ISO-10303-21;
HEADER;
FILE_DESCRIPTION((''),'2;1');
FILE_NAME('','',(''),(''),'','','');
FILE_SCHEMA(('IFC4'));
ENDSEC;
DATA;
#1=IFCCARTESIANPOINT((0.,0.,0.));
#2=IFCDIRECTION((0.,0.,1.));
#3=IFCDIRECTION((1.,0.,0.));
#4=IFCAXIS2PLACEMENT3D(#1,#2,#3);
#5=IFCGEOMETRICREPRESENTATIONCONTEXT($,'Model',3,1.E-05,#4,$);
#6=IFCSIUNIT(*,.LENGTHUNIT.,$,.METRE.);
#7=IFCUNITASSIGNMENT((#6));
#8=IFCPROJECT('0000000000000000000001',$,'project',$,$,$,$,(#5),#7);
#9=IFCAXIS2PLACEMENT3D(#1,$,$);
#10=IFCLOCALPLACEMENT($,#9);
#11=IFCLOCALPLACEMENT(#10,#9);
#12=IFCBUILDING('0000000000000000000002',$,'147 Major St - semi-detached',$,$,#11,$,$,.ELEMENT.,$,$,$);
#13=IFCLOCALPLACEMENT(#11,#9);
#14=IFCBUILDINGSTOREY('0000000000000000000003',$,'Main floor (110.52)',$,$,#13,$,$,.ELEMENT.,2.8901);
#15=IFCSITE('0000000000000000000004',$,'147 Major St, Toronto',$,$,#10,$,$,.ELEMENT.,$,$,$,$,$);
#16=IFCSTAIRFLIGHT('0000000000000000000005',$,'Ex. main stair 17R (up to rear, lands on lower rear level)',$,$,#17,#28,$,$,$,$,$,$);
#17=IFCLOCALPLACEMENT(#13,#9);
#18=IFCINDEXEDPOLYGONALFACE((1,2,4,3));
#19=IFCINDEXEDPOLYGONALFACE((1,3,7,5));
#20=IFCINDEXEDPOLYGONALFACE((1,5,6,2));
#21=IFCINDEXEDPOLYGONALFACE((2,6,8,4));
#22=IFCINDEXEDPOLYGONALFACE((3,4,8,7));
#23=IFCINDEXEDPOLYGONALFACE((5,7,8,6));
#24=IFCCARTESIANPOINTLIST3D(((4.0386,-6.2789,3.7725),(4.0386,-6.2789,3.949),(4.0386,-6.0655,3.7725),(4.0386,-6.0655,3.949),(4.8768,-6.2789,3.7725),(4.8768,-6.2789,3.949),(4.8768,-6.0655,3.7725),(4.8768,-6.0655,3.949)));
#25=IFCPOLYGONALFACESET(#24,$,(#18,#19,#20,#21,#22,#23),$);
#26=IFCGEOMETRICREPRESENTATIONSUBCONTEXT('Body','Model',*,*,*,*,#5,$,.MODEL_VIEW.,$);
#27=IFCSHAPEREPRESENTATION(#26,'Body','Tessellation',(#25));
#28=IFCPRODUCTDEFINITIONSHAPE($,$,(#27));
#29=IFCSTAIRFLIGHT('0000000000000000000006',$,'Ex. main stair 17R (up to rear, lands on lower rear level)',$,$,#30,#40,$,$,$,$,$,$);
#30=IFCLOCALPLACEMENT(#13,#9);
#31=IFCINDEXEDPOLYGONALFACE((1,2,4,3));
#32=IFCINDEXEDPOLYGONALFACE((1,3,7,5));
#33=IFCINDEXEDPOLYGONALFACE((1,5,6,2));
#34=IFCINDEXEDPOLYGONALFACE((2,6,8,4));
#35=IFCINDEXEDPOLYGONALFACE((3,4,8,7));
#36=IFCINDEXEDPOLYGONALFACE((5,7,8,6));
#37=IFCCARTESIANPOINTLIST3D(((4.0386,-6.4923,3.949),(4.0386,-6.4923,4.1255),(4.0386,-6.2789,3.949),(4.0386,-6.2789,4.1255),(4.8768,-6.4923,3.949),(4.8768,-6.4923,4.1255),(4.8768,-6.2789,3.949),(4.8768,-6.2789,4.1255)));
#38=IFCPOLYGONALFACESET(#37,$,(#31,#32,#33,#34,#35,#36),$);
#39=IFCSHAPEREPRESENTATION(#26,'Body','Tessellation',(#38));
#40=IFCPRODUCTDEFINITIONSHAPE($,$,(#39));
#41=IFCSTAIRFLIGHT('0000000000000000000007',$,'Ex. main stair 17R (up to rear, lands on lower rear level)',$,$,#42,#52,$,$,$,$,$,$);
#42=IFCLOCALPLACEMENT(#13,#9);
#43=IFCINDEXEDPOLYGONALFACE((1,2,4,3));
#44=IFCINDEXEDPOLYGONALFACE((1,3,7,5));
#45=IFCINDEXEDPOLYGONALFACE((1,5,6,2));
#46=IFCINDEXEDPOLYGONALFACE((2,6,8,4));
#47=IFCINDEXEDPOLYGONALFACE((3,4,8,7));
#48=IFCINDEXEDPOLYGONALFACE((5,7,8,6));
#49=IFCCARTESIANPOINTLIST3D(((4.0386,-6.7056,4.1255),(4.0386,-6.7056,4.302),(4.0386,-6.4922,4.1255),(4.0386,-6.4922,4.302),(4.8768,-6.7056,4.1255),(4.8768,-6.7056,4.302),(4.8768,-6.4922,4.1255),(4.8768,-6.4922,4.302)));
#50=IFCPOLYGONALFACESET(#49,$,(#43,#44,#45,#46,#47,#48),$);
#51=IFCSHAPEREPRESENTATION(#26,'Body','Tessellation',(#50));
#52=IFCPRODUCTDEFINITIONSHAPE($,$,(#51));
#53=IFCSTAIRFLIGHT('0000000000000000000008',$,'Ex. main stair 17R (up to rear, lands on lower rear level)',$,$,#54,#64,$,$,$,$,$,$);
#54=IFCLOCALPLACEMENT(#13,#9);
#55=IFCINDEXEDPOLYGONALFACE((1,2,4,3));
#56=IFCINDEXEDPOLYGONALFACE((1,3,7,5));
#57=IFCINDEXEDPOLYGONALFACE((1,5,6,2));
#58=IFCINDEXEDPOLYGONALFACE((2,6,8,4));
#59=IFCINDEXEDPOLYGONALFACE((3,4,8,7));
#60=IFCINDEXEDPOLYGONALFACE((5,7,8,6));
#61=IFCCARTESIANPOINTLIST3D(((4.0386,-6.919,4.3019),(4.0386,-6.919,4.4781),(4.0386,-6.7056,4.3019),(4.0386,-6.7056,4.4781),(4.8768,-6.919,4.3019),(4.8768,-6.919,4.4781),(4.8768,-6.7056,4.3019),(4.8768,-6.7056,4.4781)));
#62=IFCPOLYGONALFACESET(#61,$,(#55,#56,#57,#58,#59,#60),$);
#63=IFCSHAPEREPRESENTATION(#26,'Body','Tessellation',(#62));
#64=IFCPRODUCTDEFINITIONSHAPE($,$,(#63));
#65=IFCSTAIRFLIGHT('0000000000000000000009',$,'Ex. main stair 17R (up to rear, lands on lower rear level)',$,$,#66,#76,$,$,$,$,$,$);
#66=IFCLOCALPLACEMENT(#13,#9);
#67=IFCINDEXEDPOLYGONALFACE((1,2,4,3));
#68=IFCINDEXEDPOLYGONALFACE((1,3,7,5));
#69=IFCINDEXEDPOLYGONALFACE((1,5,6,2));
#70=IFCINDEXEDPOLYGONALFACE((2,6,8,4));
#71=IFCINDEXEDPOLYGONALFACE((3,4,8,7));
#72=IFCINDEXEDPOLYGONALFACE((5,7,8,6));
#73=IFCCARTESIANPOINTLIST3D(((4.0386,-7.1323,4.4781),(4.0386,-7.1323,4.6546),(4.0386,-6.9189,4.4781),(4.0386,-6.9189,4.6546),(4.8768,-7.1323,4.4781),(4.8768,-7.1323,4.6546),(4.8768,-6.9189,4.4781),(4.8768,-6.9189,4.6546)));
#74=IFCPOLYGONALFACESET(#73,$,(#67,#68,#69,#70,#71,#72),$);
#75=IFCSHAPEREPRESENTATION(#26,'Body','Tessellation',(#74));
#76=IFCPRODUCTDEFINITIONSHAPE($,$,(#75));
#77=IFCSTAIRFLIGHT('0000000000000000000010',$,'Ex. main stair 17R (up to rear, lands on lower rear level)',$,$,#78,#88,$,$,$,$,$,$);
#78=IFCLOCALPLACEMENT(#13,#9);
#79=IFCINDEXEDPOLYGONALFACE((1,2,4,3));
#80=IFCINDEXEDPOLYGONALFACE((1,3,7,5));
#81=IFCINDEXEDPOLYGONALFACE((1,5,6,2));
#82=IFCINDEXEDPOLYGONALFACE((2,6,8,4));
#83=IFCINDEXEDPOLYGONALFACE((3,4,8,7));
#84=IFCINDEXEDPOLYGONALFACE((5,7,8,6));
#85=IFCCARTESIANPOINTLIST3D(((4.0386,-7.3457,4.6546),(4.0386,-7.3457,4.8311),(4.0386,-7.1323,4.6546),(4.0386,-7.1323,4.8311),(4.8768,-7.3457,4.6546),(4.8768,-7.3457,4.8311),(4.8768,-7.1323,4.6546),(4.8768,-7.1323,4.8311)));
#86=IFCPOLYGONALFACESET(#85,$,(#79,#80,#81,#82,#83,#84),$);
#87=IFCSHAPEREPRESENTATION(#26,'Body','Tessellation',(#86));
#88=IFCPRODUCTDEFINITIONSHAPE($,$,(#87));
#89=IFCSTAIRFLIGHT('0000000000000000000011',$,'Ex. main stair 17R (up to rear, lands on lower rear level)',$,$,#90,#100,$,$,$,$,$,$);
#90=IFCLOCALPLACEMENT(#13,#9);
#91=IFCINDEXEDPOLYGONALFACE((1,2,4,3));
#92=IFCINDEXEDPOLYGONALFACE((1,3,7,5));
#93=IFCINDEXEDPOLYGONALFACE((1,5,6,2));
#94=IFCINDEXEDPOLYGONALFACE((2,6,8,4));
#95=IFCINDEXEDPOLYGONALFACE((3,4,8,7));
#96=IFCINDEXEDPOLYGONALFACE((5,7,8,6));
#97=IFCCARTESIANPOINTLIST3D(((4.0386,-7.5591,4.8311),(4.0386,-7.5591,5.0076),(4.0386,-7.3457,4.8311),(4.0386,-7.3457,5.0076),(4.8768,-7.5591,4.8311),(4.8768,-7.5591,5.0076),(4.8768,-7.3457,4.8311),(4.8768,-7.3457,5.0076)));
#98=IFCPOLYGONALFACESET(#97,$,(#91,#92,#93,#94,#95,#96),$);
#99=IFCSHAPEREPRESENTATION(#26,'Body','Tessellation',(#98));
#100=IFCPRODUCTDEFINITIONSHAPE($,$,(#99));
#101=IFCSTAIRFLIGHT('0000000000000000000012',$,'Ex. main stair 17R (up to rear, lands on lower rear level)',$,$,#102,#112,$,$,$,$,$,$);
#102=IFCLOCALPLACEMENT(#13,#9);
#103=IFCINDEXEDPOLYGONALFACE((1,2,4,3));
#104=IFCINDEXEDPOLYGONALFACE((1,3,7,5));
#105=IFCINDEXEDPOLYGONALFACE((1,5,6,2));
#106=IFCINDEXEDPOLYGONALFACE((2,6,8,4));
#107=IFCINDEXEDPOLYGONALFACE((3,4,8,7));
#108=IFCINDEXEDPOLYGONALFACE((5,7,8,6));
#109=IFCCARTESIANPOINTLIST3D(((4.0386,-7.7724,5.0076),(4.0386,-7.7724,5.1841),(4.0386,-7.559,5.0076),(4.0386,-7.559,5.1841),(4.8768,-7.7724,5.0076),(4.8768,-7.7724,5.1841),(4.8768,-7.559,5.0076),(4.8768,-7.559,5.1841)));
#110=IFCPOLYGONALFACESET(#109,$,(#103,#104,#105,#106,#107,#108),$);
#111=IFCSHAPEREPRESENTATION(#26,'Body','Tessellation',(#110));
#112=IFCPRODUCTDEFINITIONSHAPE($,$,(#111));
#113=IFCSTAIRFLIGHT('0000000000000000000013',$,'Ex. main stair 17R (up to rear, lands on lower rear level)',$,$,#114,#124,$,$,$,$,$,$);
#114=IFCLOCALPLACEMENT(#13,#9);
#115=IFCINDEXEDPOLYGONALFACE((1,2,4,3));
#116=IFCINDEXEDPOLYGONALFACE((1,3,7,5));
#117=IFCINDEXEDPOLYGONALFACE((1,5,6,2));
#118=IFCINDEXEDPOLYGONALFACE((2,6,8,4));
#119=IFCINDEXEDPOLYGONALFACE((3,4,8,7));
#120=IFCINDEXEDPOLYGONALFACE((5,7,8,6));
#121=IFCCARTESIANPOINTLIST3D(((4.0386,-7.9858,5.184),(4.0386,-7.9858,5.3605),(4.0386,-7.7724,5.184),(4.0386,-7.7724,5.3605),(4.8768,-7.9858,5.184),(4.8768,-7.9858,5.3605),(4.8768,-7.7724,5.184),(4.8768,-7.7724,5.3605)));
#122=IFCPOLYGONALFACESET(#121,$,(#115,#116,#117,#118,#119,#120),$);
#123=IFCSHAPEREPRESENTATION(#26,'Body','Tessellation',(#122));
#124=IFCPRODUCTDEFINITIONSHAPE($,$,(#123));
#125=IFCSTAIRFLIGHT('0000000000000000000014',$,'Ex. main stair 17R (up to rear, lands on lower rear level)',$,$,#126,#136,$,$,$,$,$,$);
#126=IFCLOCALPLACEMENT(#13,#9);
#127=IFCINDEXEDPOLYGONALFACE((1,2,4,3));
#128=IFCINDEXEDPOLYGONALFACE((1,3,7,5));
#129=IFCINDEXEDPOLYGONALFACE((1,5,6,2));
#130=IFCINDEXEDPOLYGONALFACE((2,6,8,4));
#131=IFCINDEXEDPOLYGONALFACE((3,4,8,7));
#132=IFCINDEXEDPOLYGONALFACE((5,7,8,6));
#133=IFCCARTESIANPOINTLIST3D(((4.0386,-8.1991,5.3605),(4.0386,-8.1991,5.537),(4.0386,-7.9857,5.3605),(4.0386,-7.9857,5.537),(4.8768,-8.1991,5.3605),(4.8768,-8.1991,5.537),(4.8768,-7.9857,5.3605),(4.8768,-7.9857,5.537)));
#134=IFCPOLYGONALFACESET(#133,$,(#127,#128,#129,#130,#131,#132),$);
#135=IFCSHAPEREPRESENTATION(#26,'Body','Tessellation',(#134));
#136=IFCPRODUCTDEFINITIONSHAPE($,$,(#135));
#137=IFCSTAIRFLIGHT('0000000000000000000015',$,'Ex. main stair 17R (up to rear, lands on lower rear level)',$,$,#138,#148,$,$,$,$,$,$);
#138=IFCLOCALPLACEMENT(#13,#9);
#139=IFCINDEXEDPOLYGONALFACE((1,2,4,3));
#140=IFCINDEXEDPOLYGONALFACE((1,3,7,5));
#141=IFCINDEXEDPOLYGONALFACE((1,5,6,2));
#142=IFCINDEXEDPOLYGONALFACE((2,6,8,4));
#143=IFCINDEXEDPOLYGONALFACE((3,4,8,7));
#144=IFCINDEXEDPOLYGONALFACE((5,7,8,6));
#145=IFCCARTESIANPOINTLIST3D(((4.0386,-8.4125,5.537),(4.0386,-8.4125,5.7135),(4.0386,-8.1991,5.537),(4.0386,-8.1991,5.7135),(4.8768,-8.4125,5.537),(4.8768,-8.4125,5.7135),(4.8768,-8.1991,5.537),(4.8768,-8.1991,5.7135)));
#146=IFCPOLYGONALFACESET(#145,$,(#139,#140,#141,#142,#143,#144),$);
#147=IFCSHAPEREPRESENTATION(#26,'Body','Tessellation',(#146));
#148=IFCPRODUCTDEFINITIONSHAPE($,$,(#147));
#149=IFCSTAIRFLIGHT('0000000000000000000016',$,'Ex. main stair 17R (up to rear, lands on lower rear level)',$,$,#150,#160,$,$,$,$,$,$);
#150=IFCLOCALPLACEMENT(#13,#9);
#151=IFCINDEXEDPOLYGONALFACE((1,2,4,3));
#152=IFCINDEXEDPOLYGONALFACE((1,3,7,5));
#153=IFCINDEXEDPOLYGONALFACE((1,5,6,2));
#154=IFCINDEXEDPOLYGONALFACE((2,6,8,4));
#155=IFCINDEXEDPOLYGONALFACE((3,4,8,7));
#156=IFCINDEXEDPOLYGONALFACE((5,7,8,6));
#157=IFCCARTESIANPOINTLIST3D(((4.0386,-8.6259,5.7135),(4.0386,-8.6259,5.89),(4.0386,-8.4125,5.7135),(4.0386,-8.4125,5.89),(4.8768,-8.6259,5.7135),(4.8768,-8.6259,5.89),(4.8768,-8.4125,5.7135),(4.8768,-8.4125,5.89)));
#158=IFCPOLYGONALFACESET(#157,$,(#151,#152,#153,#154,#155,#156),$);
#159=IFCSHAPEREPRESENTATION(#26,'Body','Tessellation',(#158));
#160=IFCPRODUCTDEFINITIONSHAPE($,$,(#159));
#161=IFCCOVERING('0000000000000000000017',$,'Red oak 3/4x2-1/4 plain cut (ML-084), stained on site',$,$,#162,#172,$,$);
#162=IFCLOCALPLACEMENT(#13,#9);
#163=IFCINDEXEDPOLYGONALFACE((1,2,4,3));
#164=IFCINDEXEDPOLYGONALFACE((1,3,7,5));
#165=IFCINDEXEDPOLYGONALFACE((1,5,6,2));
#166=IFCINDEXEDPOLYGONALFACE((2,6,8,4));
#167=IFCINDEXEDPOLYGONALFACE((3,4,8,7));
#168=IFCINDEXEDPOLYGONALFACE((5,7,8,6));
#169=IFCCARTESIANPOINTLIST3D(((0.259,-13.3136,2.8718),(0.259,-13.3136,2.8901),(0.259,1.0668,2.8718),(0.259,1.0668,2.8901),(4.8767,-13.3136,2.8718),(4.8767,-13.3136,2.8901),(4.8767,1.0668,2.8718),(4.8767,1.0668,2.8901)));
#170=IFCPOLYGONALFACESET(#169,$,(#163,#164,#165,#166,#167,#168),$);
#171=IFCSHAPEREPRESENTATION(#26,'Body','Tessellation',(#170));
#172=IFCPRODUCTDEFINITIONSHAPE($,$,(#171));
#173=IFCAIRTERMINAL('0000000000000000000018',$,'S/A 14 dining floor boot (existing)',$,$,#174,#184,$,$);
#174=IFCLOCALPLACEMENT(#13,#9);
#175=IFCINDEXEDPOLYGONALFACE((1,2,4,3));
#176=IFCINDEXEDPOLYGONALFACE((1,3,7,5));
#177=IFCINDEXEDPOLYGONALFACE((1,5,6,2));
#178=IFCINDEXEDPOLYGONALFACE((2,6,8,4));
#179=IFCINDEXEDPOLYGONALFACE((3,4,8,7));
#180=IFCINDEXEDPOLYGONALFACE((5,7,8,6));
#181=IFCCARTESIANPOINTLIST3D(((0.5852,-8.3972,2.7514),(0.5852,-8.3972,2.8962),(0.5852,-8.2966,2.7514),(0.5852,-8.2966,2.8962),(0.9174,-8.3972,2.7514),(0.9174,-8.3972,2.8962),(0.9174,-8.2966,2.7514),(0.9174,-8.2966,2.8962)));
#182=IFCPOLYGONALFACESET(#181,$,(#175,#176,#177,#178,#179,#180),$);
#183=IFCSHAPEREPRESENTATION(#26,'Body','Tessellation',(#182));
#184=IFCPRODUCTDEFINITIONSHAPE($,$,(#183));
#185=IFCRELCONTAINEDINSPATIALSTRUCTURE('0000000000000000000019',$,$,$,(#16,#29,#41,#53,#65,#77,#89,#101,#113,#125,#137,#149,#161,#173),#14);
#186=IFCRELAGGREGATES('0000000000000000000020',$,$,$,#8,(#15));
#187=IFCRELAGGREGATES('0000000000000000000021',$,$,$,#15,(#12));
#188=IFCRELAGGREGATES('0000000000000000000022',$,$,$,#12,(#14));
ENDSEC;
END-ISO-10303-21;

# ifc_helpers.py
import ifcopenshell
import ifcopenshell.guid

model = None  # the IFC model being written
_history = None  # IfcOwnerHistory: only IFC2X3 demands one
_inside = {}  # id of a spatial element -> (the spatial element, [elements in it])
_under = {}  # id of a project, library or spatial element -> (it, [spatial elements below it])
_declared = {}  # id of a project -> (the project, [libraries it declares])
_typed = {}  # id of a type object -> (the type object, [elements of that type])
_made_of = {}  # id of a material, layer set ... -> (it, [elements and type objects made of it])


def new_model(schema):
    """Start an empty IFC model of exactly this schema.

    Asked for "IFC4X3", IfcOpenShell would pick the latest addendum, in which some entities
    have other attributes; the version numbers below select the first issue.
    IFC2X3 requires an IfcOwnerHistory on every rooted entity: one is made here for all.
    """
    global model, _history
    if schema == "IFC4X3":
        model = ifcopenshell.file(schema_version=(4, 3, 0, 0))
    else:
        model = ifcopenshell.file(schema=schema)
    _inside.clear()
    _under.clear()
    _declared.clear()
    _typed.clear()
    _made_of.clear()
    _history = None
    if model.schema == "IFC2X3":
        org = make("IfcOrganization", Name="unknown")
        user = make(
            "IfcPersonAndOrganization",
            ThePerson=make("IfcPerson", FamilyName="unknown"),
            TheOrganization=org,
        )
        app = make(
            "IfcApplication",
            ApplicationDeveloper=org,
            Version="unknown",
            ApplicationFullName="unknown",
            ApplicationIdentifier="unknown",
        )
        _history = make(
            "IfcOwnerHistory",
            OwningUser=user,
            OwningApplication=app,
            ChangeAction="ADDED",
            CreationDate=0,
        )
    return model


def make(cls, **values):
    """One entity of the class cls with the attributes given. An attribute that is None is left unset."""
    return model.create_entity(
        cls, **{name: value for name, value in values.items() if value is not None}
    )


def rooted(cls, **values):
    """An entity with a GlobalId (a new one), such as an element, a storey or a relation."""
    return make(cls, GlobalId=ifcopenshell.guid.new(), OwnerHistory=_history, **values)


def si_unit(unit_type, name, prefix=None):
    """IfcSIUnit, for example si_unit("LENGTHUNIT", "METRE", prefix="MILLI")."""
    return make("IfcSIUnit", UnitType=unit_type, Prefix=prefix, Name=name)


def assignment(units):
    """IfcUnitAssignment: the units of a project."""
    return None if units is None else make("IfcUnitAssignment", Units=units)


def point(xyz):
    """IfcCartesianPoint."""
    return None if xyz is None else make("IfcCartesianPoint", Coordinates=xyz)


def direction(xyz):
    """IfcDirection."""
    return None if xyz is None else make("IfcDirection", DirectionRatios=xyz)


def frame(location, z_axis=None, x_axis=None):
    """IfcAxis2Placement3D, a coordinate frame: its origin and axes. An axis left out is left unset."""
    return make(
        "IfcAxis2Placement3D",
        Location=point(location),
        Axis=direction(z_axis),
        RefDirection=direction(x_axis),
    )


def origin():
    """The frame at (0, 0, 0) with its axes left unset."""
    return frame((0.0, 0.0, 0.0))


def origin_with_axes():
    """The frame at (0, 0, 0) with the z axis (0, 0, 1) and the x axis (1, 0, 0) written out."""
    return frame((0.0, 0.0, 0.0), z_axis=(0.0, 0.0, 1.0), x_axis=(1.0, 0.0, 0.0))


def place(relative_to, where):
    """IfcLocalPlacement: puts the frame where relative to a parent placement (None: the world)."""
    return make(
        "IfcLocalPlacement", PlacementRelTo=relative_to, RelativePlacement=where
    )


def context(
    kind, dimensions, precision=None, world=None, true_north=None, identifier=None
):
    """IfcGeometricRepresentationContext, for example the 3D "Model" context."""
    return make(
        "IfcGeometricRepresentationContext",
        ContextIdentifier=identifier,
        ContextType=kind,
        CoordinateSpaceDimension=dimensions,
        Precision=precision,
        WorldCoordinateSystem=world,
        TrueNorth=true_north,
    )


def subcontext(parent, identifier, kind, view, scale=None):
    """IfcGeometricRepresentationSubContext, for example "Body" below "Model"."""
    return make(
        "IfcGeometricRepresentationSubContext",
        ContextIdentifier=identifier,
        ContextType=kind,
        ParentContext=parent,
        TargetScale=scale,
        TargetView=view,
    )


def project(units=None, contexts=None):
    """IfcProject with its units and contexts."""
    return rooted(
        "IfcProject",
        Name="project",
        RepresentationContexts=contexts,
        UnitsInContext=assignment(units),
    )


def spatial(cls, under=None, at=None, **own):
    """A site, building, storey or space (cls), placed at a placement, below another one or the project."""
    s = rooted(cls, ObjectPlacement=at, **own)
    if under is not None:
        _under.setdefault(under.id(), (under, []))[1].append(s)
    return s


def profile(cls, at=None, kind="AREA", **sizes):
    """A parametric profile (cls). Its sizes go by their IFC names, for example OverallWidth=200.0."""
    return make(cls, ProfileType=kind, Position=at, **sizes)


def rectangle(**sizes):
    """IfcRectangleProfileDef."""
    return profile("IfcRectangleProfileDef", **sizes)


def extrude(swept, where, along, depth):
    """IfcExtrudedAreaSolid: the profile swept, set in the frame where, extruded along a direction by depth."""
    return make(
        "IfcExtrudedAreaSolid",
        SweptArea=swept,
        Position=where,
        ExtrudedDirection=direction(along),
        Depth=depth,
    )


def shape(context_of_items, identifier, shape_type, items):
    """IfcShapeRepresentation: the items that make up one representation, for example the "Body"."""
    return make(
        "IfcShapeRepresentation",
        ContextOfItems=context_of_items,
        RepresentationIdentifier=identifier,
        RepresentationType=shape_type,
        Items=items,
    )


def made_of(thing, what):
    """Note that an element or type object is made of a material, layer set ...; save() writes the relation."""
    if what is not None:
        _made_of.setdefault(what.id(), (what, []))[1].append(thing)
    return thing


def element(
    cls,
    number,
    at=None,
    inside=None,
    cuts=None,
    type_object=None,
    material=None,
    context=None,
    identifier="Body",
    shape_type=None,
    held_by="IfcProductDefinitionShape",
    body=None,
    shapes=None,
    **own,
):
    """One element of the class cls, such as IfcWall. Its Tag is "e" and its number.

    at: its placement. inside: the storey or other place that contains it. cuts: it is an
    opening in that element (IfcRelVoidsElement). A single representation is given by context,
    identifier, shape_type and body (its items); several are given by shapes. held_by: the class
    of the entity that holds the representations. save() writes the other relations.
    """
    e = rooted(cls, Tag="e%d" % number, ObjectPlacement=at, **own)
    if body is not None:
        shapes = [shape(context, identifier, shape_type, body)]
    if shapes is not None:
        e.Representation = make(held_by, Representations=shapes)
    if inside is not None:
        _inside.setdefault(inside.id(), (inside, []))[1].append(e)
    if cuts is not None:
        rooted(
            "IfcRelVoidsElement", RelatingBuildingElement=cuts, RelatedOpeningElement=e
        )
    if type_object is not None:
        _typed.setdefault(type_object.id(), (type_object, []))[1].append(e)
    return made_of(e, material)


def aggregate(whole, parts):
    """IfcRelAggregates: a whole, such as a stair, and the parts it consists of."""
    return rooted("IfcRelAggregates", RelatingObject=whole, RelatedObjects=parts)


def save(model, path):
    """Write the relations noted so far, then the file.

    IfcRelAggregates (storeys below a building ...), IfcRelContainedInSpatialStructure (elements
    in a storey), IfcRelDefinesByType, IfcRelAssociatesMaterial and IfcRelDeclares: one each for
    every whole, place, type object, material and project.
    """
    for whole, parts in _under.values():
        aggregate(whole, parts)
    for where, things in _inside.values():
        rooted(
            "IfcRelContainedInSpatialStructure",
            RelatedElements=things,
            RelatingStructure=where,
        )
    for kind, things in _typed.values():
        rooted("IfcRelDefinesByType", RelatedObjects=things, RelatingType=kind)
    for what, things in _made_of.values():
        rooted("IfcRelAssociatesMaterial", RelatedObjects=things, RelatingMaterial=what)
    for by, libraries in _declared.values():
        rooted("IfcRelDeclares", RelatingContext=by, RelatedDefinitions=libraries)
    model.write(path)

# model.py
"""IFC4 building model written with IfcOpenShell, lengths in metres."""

from ifc_helpers import new_model, si_unit, frame, origin, origin_with_axes, place, context, subcontext, project, spatial, rectangle, extrude, element, save


model = new_model("IFC4")

# Units and contexts
model_context = context("Model", 3, precision=1e-05, world=origin_with_axes())
body_context = subcontext(model_context, "Body", "Model", "MODEL_VIEW")
ifc_project = project(units=[si_unit("LENGTHUNIT", "METRE")], contexts=[model_context])

# Site, building, storey
site_placement = place(None, origin())
site = spatial("IfcSite", under=ifc_project, at=site_placement, Name="147 Major St, Toronto", CompositionType="ELEMENT")
building_placement = place(site_placement, origin())
building = spatial("IfcBuilding", under=site, at=building_placement, Name="147 Major St - semi-detached", CompositionType="ELEMENT")
storey_placement = place(building_placement, origin())
storey = spatial("IfcBuildingStorey", under=building, at=storey_placement, Name="Main floor (110.52)", CompositionType="ELEMENT", Elevation=2.8901)

# Stair flights
for number, where, name in (
    (1, (4.4577, -6.1722, 3.7725), "Ex. main stair 17R (up to rear, lands on lower rear level)"),
    (2, (4.4577, -6.3856, 3.949), "Ex. main stair 17R (up to rear, lands on lower rear level)"),
    (3, (4.4577, -6.5989, 4.1255), "Ex. main stair 17R (up to rear, lands on lower rear level)"),
):
    element("IfcStairFlight", number, at=place(storey_placement, frame(where)), inside=storey, Name=name, context=body_context, shape_type="SweptSolid", body=[
        extrude(rectangle(XDim=0.8382, YDim=0.2134), origin_with_axes(), (0.0, 0.0, 1.0), 0.1765),
    ])
stair_flight_placement = place(storey_placement, frame((4.4577, -6.8123, 4.3019)))
element("IfcStairFlight", 4, at=stair_flight_placement, inside=storey, Name="Ex. main stair 17R (up to rear, lands on lower rear level)", context=body_context, shape_type="SweptSolid", body=[
    extrude(rectangle(XDim=0.8382, YDim=0.2134), origin_with_axes(), (0.0, 0.0, 1.0), 0.1762),
])
for number, where, name in (
    (5, (4.4577, -7.0256, 4.4781), "Ex. main stair 17R (up to rear, lands on lower rear level)"),
    (6, (4.4577, -7.239, 4.6546), "Ex. main stair 17R (up to rear, lands on lower rear level)"),
    (7, (4.4577, -7.4524, 4.8311), "Ex. main stair 17R (up to rear, lands on lower rear level)"),
    (8, (4.4577, -7.6657, 5.0076), "Ex. main stair 17R (up to rear, lands on lower rear level)"),
    (9, (4.4577, -7.8791, 5.184), "Ex. main stair 17R (up to rear, lands on lower rear level)"),
    (10, (4.4577, -8.0924, 5.3605), "Ex. main stair 17R (up to rear, lands on lower rear level)"),
    (11, (4.4577, -8.3058, 5.537), "Ex. main stair 17R (up to rear, lands on lower rear level)"),
    (12, (4.4577, -8.5192, 5.7135), "Ex. main stair 17R (up to rear, lands on lower rear level)"),
):
    element("IfcStairFlight", number, at=place(storey_placement, frame(where)), inside=storey, Name=name, context=body_context, shape_type="SweptSolid", body=[
        extrude(rectangle(XDim=0.8382, YDim=0.2134), origin_with_axes(), (0.0, 0.0, 1.0), 0.1765),
    ])

# Covering
covering_placement = place(storey_placement, frame((2.5679, -6.1234, 2.8718)))
element("IfcCovering", 13, at=covering_placement, inside=storey, Name="Red oak 3/4x2-1/4 plain cut (ML-084), stained on site", context=body_context, shape_type="SweptSolid", body=[
    extrude(rectangle(XDim=4.6177, YDim=14.3805), origin_with_axes(), (0.0, 0.0, 1.0), 0.0183),
])

# Air terminal
air_terminal_placement = place(storey_placement, frame((0.7513, -8.3469, 2.7514)))
element("IfcAirTerminal", 14, at=air_terminal_placement, inside=storey, Name="S/A 14 dining floor boot (existing)", context=body_context, shape_type="SweptSolid", body=[
    extrude(rectangle(XDim=0.3322, YDim=0.1006), origin_with_axes(), (0.0, 0.0, 1.0), 0.1448),
])

save(model, "model.ifc")
